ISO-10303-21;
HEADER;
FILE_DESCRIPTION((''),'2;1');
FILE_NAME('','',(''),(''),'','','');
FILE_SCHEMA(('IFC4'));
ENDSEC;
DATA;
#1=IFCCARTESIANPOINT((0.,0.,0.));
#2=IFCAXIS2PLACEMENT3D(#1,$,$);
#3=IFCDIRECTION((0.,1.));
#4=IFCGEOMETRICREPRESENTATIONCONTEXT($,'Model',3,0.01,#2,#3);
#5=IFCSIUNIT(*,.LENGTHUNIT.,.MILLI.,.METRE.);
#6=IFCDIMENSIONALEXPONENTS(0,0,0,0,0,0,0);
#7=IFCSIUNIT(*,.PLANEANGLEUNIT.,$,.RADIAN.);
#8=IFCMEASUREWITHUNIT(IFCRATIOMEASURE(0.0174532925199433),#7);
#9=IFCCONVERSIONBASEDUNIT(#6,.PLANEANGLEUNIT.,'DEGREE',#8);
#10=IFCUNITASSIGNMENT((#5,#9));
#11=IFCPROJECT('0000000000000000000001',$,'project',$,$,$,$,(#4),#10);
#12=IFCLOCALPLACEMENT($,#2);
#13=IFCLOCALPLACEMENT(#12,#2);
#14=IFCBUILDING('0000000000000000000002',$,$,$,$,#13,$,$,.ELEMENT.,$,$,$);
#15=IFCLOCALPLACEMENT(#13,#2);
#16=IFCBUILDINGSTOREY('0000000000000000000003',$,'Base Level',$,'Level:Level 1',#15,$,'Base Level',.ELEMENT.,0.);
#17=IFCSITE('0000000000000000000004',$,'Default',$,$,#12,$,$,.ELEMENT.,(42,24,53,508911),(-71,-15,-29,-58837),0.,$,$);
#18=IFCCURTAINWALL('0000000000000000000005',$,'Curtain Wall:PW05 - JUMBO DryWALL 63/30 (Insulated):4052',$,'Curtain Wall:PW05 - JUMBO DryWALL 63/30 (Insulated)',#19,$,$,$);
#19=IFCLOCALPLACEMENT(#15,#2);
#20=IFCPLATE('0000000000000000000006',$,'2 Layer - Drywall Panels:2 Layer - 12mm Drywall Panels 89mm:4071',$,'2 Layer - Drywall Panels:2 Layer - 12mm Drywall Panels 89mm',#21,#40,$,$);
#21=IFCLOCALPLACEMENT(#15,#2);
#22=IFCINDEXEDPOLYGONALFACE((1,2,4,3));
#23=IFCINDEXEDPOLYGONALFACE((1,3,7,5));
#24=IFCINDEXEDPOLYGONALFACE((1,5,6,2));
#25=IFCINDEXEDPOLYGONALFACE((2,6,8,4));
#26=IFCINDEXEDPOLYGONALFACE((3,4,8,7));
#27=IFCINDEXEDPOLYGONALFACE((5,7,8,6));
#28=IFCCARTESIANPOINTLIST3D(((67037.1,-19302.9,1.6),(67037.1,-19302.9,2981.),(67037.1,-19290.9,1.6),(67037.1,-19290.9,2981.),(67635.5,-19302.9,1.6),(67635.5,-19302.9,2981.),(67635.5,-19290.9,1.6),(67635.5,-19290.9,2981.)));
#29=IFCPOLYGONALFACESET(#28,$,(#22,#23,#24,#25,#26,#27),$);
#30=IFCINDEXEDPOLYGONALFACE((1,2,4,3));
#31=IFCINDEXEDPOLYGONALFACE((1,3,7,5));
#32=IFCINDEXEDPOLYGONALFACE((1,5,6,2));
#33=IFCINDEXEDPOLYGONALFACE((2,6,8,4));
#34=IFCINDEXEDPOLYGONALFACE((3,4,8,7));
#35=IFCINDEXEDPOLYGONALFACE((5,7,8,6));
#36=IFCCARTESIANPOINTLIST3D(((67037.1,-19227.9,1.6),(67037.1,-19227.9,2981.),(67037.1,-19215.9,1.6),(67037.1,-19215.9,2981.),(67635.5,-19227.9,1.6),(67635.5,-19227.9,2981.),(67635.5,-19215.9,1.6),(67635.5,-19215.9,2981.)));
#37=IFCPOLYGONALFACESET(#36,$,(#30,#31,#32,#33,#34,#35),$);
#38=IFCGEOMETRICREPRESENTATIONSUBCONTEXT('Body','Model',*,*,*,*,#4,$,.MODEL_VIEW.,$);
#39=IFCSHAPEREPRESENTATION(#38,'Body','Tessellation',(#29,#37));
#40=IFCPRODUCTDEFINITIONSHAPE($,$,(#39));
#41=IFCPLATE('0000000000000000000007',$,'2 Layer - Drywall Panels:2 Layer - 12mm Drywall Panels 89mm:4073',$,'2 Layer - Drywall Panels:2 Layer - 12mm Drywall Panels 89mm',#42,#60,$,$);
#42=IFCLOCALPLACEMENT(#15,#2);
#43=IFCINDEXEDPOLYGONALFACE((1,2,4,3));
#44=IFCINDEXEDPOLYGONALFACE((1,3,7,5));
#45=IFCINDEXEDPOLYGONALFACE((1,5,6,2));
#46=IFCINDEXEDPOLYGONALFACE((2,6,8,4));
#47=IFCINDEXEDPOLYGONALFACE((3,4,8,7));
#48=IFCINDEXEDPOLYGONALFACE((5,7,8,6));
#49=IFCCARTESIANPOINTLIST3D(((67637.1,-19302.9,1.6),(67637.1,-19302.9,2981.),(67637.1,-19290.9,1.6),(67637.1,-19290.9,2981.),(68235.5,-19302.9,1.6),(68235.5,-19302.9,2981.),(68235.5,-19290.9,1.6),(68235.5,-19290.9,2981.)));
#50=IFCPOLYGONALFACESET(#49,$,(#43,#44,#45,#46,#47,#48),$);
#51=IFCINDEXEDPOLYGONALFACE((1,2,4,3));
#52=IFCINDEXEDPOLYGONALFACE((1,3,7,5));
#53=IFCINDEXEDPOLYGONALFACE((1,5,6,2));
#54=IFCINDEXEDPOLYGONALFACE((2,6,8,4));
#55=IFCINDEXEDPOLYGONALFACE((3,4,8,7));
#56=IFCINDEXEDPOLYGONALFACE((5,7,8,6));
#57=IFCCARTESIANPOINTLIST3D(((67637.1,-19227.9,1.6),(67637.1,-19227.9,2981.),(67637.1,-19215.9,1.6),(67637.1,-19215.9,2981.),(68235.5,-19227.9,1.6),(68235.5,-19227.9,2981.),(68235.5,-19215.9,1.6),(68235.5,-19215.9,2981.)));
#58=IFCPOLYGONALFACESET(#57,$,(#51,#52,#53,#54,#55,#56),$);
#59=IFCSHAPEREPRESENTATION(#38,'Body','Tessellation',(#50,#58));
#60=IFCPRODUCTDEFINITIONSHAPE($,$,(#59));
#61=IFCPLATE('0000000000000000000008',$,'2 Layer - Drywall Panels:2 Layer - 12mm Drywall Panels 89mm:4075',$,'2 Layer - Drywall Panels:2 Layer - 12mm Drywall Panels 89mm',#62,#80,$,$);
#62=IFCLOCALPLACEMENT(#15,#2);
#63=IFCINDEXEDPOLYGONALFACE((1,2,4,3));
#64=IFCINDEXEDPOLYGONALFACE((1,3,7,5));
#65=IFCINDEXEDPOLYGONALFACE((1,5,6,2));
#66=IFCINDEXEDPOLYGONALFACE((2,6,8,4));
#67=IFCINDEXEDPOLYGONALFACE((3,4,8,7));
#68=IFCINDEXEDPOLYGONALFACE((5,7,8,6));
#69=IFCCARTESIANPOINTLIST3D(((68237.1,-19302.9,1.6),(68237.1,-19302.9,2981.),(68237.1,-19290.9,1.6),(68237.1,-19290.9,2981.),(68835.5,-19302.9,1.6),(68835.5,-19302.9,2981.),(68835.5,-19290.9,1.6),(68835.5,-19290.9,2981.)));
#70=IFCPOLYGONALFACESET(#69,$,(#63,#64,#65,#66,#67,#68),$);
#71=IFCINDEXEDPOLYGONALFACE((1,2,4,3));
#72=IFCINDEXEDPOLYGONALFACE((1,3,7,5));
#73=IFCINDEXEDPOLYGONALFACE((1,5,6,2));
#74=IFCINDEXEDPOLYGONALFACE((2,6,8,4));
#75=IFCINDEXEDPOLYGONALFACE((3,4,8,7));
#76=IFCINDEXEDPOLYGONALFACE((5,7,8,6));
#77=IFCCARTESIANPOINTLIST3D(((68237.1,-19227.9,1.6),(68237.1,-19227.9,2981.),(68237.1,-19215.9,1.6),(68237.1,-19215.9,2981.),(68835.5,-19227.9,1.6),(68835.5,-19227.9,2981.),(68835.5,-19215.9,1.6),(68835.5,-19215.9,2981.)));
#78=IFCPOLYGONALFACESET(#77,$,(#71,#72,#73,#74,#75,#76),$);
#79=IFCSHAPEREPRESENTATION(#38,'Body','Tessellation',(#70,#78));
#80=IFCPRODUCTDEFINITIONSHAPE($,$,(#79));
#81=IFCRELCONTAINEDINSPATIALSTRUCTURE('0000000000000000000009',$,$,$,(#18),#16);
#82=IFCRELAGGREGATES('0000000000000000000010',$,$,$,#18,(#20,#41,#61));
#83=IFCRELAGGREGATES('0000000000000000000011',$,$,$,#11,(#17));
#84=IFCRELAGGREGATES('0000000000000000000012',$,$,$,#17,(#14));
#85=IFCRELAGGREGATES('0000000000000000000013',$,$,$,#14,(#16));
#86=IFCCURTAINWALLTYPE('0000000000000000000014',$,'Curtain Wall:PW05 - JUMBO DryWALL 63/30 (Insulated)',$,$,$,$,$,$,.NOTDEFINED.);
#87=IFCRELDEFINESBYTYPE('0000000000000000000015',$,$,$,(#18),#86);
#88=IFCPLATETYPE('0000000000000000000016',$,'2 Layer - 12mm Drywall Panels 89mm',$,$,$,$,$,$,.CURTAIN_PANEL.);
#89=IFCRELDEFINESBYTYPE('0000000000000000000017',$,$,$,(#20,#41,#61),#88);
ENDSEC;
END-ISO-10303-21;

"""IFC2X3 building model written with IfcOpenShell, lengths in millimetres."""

from ifc_helpers import new_model, entity, si_unit, converted_unit, direction, frame, frame_2d, origin, place, context, subcontext, project, spatial, rectangle, extrude, source, transform, mapped, type_object, type_shapes, element, aggregate, save


model = new_model("IFC2X3")

# Units and contexts
model_context = context("Model", 3, precision=0.01, world=origin(), true_north=direction((0.0, 1.0)))
body_context = subcontext(model_context, "Body", "Model", "MODEL_VIEW")
ifc_project = project(units=[si_unit("LENGTHUNIT", "METRE", prefix="MILLI"), converted_unit("PLANEANGLEUNIT", "DEGREE", entity("IfcRatioMeasure", 0.0174532925199433), si_unit("PLANEANGLEUNIT", "RADIAN"), dimensions=[0, 0, 0, 0, 0, 0, 0])], contexts=[model_context])

# Site, building, storey
site_placement = place(None, origin())
site = spatial("IfcSite", under=ifc_project, at=site_placement, Name="Default", CompositionType="ELEMENT", RefLatitude=(42, 24, 53, 508911), RefLongitude=(-71, -15, -29, -58837), RefElevation=0.0)
building_placement = place(site_placement, origin())
building = spatial("IfcBuilding", under=site, at=building_placement, CompositionType="ELEMENT")
storey_placement = place(building_placement, origin())
storey = spatial("IfcBuildingStorey", under=building, at=storey_placement, Name="Base Level", ObjectType="Level:Level 1", LongName="Base Level", CompositionType="ELEMENT", Elevation=0.0)

# Curtain wall, plates
curtain_wall_type = type_object("IfcCurtainWallType", Name="Curtain Wall:PW05 - JUMBO DryWALL 63/30 (Insulated)", PredefinedType="NOTDEFINED")
curtain_wall_placement = place(building_placement, origin())
curtain_wall = element("IfcCurtainWall", 1, at=curtain_wall_placement, inside=storey, type_object=curtain_wall_type, Name="Curtain Wall:PW05 - JUMBO DryWALL 63/30 (Insulated):4052", ObjectType="Curtain Wall:PW05 - JUMBO DryWALL 63/30 (Insulated)")
plate_type = type_object("IfcPlateType", Name="2 Layer - 12mm Drywall Panels 89mm", PredefinedType="CURTAIN_PANEL")
shared_shape_1 = source(origin(), body_context, "Body", "SweptSolid", [
    extrude(rectangle(XDim=598.4, YDim=12.0, at=frame_2d((0.0, 0.0), x_axis=(1.0, 0.0))), frame((0.0, -37.5, 0.0), z_axis=(0.0, 0.0, 1.0), x_axis=(-1.0, 0.0, 0.0)), (0.0, 0.0, 1.0), 2979.4),
    extrude(rectangle(XDim=12.0, YDim=598.4, at=frame_2d((0.0, 0.0), x_axis=(1.0, 0.0))), frame((0.0, 37.5, 0.0), z_axis=(0.0, 0.0, 1.0), x_axis=(0.0, 1.0, 0.0)), (0.0, 0.0, 1.0), 2979.4),
])
type_shapes(plate_type, [shared_shape_1])
plate_1_placement = place(curtain_wall_placement, frame((67336.3, -19259.4, 1.6)))
plate_1 = element("IfcPlate", 2, at=plate_1_placement, type_object=plate_type, Name="2 Layer - Drywall Panels:2 Layer - 12mm Drywall Panels 89mm:4071", ObjectType="2 Layer - Drywall Panels:2 Layer - 12mm Drywall Panels 89mm", context=body_context, shape_type="MappedRepresentation", body=[
    mapped(shared_shape_1, transform((0.0, 0.0, 0.0), scale=1.0)),
])
plate_2_placement = place(curtain_wall_placement, frame((67936.3, -19259.4, 1.6)))
plate_2 = element("IfcPlate", 3, at=plate_2_placement, type_object=plate_type, Name="2 Layer - Drywall Panels:2 Layer - 12mm Drywall Panels 89mm:4073", ObjectType="2 Layer - Drywall Panels:2 Layer - 12mm Drywall Panels 89mm", context=body_context, shape_type="MappedRepresentation", body=[
    mapped(shared_shape_1, transform((0.0, 0.0, 0.0), scale=1.0)),
])
plate_3_placement = place(curtain_wall_placement, frame((68536.3, -19259.4, 1.6)))
plate_3 = element("IfcPlate", 4, at=plate_3_placement, type_object=plate_type, Name="2 Layer - Drywall Panels:2 Layer - 12mm Drywall Panels 89mm:4075", ObjectType="2 Layer - Drywall Panels:2 Layer - 12mm Drywall Panels 89mm", context=body_context, shape_type="MappedRepresentation", body=[
    mapped(shared_shape_1, transform((0.0, 0.0, 0.0), scale=1.0)),
])
aggregate(curtain_wall, [plate_1, plate_2, plate_3])

save(model, "model.ifc")
